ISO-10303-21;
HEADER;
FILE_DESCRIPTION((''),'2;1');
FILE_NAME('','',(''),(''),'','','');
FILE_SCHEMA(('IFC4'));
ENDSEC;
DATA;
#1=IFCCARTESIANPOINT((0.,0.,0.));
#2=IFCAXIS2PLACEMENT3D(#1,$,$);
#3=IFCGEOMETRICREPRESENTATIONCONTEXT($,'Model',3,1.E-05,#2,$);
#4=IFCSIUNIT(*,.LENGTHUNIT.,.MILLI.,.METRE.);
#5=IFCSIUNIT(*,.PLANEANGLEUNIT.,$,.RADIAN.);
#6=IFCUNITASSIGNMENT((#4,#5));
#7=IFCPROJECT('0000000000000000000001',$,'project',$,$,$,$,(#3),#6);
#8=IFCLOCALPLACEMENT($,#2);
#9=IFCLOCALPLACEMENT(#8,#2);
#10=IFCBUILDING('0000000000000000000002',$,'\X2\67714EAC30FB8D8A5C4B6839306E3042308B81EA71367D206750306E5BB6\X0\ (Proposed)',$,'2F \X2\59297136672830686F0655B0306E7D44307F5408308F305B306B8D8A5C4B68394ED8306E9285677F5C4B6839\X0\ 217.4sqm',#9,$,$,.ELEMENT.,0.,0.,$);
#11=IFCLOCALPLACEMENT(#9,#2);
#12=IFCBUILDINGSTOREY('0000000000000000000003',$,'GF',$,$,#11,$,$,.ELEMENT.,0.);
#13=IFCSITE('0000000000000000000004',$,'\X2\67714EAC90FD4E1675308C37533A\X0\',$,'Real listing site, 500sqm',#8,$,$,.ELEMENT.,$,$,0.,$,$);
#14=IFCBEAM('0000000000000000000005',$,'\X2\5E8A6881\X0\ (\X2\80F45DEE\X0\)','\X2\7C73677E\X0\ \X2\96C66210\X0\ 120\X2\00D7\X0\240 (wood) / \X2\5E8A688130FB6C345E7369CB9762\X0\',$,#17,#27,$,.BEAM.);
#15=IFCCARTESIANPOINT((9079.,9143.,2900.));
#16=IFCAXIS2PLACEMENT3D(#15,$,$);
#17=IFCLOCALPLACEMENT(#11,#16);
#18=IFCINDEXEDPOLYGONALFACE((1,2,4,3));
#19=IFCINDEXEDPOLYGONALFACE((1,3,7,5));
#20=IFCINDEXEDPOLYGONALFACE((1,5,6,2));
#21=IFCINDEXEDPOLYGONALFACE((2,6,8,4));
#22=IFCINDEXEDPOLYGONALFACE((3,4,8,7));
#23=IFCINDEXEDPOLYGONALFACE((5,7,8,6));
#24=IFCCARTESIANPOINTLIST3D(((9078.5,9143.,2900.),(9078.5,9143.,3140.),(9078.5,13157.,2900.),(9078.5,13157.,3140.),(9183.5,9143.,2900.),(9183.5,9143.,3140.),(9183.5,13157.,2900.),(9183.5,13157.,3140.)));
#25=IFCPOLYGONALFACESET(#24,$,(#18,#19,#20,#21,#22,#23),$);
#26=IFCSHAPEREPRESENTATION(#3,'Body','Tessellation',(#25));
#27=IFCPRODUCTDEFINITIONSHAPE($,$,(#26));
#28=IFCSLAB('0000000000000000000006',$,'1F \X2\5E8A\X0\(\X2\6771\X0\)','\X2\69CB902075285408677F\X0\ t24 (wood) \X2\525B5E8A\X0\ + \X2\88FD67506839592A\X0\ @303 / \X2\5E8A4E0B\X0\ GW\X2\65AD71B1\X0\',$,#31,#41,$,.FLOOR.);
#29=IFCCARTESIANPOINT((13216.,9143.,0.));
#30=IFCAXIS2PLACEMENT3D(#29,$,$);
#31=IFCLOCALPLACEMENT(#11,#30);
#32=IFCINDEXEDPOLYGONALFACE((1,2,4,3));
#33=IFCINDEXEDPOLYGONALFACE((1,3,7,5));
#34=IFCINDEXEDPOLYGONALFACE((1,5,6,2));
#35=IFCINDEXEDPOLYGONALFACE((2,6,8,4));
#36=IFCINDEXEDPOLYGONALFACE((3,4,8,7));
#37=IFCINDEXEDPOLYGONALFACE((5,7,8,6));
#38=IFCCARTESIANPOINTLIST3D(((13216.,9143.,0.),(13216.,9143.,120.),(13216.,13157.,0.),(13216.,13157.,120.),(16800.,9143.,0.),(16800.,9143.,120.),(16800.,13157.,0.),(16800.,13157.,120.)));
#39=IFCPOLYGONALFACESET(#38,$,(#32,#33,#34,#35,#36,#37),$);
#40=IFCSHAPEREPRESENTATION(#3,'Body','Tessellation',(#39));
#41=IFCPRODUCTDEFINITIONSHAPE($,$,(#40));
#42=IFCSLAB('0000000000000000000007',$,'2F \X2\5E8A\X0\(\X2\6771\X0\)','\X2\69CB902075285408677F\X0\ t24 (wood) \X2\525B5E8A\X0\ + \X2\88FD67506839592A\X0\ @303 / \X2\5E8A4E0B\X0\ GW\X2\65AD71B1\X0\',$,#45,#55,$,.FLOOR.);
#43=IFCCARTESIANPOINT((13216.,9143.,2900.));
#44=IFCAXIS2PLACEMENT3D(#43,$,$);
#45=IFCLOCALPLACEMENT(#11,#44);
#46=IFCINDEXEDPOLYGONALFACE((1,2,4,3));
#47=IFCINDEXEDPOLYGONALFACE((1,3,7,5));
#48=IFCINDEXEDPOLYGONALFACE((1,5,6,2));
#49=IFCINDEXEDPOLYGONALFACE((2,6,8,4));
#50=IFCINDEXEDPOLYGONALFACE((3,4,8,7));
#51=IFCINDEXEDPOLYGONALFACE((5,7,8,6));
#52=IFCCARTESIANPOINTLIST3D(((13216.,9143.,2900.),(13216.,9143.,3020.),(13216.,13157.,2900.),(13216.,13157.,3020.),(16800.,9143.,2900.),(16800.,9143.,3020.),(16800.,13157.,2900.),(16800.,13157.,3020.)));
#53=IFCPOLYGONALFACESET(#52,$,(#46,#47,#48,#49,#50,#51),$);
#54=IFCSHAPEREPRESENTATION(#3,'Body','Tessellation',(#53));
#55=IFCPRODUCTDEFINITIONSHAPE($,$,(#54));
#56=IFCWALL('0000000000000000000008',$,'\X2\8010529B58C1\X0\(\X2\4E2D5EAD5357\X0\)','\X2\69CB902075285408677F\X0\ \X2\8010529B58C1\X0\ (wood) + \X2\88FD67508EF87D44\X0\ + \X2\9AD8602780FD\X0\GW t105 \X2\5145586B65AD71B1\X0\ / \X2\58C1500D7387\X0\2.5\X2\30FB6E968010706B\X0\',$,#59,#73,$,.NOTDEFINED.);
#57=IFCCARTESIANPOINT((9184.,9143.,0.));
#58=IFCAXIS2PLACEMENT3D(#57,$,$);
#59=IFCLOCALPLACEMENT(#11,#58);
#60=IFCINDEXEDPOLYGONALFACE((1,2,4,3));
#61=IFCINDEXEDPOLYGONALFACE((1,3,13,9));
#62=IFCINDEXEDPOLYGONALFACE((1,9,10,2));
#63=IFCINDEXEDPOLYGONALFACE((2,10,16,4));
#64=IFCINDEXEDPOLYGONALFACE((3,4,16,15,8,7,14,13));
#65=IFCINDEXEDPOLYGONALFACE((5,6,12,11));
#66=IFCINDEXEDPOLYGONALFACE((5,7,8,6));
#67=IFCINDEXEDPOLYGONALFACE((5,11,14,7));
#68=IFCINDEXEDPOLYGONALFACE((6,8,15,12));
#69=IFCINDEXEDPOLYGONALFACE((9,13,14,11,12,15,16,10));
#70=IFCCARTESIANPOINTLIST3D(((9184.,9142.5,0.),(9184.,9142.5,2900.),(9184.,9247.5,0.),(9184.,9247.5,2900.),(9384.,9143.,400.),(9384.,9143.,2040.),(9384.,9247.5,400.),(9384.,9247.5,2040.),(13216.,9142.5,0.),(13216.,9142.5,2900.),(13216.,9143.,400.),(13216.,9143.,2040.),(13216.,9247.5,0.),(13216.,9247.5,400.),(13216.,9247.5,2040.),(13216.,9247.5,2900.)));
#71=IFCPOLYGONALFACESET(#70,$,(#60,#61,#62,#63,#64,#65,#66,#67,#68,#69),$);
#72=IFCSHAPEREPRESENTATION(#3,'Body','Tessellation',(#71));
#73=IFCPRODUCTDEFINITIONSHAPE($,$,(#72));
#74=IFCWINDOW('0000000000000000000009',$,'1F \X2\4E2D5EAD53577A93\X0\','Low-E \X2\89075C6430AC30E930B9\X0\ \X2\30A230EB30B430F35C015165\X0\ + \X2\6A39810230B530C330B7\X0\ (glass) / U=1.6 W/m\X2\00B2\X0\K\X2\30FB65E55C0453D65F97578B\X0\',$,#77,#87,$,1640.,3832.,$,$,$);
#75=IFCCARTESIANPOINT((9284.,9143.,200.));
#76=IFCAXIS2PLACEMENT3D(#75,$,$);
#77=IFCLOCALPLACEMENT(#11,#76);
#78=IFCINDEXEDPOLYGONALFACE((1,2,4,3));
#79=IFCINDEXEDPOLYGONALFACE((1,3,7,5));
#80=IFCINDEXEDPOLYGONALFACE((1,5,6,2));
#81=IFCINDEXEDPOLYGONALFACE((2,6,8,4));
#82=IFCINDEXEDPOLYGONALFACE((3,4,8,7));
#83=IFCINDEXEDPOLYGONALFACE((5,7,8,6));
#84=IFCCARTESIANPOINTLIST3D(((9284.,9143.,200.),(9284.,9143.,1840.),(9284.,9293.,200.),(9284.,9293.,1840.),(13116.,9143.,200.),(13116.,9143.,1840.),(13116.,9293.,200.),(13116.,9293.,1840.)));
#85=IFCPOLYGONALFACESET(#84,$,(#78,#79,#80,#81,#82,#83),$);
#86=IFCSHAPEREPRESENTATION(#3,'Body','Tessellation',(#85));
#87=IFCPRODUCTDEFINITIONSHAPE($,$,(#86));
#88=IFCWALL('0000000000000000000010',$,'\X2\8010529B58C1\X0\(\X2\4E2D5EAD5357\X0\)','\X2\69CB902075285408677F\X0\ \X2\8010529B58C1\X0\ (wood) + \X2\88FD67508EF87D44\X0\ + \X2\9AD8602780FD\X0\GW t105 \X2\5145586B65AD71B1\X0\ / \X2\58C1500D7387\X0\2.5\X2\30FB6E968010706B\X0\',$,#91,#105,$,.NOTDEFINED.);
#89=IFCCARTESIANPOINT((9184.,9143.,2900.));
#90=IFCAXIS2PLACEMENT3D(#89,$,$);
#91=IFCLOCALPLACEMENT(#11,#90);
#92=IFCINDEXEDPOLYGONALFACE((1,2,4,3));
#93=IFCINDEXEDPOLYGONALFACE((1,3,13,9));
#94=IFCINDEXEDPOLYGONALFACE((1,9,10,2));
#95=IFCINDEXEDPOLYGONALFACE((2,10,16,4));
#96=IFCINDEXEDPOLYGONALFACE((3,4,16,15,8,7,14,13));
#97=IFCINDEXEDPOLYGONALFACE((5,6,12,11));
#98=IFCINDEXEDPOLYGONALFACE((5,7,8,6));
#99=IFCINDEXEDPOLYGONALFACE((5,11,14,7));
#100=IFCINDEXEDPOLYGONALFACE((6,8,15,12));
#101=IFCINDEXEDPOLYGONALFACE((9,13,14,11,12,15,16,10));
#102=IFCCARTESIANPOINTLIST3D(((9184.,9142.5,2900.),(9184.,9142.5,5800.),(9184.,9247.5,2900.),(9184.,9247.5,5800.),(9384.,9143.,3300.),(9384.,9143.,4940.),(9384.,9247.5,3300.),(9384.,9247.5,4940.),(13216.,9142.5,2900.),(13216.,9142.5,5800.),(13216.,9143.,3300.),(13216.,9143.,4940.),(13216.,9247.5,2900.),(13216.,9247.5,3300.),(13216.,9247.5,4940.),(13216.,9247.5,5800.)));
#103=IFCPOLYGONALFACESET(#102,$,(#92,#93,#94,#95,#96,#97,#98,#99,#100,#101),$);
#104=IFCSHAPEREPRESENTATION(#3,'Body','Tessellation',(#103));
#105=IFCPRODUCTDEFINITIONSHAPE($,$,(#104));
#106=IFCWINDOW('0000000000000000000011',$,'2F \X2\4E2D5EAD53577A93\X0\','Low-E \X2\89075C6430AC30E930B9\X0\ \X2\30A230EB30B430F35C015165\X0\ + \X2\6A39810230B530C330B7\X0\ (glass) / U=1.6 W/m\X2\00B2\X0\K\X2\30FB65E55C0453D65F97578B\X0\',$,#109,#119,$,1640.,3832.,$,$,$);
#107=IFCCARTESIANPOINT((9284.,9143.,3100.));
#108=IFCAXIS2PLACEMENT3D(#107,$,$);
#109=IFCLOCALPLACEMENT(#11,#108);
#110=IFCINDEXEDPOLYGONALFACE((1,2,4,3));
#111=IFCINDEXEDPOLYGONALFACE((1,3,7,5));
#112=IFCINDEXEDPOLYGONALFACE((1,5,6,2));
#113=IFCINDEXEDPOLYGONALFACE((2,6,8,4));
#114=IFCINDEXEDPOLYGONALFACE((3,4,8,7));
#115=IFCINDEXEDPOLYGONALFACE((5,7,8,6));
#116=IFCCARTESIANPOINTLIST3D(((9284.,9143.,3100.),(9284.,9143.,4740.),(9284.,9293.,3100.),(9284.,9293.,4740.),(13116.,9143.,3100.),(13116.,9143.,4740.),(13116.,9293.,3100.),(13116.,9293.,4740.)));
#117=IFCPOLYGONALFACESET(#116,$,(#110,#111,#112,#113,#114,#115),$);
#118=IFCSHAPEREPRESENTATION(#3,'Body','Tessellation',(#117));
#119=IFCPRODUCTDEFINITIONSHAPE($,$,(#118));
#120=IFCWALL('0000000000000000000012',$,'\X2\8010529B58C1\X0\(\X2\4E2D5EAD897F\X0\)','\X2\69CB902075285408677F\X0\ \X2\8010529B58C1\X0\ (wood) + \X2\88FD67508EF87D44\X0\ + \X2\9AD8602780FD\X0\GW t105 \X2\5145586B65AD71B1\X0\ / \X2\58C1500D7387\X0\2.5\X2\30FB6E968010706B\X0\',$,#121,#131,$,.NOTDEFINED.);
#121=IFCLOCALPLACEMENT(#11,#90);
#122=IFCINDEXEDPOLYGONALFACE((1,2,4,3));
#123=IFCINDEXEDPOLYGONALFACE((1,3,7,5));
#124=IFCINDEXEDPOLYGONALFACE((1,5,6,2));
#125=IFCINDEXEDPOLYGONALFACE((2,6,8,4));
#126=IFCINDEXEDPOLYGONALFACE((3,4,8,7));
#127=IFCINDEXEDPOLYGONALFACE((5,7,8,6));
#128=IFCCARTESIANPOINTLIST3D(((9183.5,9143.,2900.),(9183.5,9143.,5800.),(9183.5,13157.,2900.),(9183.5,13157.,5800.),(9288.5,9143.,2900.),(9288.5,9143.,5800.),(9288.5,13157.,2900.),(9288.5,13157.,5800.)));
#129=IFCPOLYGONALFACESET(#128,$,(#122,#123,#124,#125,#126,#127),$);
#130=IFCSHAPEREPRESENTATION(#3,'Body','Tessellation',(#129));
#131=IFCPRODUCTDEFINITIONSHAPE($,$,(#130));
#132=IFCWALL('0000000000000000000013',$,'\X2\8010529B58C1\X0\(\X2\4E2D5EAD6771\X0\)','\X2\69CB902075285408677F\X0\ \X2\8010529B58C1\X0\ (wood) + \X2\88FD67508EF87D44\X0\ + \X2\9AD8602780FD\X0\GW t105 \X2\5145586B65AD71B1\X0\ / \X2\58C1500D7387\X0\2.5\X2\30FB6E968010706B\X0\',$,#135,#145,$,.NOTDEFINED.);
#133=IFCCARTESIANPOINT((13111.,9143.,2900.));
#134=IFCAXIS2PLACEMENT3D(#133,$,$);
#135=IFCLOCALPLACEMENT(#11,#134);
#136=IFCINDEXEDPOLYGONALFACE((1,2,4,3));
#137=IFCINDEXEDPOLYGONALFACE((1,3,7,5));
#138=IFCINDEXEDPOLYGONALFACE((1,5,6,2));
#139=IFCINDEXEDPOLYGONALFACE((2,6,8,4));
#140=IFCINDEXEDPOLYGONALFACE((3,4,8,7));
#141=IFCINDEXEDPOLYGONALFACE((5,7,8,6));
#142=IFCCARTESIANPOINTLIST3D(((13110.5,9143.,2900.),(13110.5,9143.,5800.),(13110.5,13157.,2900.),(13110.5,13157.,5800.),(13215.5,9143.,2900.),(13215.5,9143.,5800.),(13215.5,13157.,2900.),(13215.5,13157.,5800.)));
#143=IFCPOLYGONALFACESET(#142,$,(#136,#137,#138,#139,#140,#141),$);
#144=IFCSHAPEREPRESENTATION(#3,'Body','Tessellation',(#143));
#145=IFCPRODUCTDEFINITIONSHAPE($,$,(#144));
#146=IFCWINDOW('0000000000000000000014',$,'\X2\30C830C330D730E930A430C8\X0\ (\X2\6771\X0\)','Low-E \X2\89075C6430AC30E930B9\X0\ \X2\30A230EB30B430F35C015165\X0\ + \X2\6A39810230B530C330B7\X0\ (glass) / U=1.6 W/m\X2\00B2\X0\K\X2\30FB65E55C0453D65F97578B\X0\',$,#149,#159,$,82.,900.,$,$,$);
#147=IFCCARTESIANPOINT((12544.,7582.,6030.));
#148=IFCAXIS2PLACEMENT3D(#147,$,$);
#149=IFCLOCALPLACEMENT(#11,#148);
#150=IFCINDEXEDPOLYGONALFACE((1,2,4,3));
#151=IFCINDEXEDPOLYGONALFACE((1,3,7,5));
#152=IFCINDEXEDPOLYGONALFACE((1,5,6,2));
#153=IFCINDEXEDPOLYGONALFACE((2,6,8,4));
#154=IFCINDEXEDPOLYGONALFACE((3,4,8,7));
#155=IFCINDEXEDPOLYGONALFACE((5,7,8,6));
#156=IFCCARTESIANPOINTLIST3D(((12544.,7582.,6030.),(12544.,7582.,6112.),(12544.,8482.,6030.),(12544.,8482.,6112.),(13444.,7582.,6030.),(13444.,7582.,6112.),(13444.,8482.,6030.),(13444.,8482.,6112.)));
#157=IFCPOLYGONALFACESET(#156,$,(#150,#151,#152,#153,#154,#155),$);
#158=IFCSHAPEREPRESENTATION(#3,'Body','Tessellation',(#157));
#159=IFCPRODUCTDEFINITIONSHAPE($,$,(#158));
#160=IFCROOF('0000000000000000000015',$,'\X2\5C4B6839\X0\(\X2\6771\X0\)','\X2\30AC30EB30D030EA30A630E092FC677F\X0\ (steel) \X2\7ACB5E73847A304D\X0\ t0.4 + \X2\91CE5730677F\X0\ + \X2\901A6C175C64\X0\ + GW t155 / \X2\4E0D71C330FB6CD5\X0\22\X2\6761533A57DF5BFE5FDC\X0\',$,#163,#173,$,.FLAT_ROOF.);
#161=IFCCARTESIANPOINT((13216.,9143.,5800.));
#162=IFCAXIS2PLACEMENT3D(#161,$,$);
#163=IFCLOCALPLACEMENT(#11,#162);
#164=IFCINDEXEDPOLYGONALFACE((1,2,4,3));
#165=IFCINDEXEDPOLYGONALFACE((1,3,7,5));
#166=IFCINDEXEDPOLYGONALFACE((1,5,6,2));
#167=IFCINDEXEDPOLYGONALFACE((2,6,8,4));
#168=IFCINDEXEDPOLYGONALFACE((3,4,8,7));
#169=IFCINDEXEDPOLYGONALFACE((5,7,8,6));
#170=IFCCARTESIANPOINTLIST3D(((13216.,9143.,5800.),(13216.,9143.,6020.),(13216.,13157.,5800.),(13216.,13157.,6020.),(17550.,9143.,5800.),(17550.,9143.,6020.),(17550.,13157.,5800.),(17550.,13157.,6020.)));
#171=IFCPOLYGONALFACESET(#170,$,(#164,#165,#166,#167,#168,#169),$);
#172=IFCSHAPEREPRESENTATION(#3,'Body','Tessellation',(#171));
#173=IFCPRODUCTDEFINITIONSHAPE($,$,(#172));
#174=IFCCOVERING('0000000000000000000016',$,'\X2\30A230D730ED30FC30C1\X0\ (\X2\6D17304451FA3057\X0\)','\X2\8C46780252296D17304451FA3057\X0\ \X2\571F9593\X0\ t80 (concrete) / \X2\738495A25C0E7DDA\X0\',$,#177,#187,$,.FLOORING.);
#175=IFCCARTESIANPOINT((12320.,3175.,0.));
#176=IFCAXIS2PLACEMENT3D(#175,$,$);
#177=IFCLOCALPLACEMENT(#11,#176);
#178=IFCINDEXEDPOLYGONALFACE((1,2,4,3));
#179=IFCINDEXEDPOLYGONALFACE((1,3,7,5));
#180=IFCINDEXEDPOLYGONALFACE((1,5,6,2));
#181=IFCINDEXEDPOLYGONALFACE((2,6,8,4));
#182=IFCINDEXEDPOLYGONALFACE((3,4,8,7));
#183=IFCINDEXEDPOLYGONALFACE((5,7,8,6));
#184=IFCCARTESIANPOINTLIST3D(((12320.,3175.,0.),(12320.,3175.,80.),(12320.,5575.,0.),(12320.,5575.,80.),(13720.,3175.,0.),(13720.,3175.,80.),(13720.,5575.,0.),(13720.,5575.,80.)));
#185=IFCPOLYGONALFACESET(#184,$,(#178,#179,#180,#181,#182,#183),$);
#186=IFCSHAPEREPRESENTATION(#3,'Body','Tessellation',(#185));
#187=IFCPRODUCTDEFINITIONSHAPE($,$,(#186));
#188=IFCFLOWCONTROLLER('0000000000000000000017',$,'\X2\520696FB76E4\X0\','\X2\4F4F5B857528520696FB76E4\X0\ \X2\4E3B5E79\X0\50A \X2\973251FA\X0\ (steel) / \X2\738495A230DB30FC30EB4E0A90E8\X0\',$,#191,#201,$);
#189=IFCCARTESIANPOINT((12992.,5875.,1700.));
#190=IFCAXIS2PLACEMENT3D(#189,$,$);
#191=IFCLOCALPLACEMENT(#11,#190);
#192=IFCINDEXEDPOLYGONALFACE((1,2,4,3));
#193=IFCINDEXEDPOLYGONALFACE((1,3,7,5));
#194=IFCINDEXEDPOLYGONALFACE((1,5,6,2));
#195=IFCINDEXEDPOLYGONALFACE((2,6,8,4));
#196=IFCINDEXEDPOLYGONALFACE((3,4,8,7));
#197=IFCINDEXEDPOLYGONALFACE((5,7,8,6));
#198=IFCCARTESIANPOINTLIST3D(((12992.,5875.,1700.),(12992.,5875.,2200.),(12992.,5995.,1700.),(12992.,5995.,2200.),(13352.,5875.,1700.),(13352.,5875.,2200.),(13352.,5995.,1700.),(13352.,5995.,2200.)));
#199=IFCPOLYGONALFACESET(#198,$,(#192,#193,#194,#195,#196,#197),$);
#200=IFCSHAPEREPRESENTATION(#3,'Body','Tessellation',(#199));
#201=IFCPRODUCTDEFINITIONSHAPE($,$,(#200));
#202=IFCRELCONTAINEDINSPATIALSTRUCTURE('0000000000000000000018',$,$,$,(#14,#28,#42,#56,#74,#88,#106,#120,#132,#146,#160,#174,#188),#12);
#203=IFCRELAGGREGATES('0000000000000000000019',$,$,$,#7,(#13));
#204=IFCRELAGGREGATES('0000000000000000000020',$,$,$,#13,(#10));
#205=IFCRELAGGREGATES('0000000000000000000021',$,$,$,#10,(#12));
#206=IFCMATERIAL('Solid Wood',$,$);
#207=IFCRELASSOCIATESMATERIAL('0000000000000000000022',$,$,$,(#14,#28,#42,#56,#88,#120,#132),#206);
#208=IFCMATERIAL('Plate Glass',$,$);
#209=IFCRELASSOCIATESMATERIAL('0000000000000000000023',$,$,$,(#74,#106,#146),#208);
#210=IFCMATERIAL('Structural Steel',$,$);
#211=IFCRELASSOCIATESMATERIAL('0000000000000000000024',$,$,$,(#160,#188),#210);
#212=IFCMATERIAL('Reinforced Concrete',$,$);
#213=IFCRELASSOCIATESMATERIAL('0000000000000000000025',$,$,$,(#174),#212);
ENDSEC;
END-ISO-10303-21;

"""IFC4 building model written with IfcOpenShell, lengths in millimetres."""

from ifc_helpers import new_model, si_unit, frame, frame_2d, origin, place, context, project, spatial, rectangle, extrude, material, element, fill, save


model = new_model("IFC4")

# Units and contexts
model_context = context("Model", 3, precision=1e-05, world=origin())
ifc_project = project(units=[si_unit("LENGTHUNIT", "METRE", prefix="MILLI"), si_unit("PLANEANGLEUNIT", "RADIAN")], contexts=[model_context])

# Site, building, storey
site_placement = place(None, origin())
site = spatial("IfcSite", under=ifc_project, at=site_placement, Name="東京都世田谷区", ObjectType="Real listing site, 500sqm", CompositionType="ELEMENT", RefElevation=0.0)
building_placement = place(site_placement, origin())
building = spatial("IfcBuilding", under=site, at=building_placement, Name="東京・越屋根のある自然素材の家 (Proposed)", ObjectType="2F 天然木と漆喰の組み合わせに越屋根付の銅板屋根 217.4sqm", CompositionType="ELEMENT", ElevationOfRefHeight=0.0, ElevationOfTerrain=0.0)
storey_placement = place(building_placement, origin())
storey = spatial("IfcBuildingStorey", under=building, at=storey_placement, Name="GF", CompositionType="ELEMENT", Elevation=0.0)

# Shared definitions
ifc_material_1 = material(Name="Solid Wood")

# Beam
beam_placement = place(storey_placement, frame((9079.0, 9143.0, 2900.0)))
element("IfcBeam", 1, at=beam_placement, inside=storey, material=ifc_material_1, Name="床梁 (胴差)", Description="米松 集成 120×240 (wood) / 床梁・水平構面", PredefinedType="BEAM", context=model_context, shape_type="SweptSolid", body=[
    extrude(rectangle(XDim=105.0, YDim=4014.0, at=frame_2d((52.0, 2007.0))), frame((9079.0, 9143.0, 2900.0)), (0.0, 0.0, 1.0), 240.0),
])

# Slabs
slab_1_placement = place(storey_placement, frame((13216.0, 9143.0, 0.0)))
element("IfcSlab", 2, at=slab_1_placement, inside=storey, material=ifc_material_1, Name="1F 床(東)", Description="構造用合板 t24 (wood) 剛床 + 製材根太 @303 / 床下 GW断熱", PredefinedType="FLOOR", context=model_context, shape_type="SweptSolid", body=[
    extrude(rectangle(XDim=3584.0, YDim=4014.0, at=frame_2d((1792.0, 2007.0))), frame((13216.0, 9143.0, 0.0)), (0.0, 0.0, 1.0), 120.0),
])
slab_2_placement = place(storey_placement, frame((13216.0, 9143.0, 2900.0)))
element("IfcSlab", 3, at=slab_2_placement, inside=storey, material=ifc_material_1, Name="2F 床(東)", Description="構造用合板 t24 (wood) 剛床 + 製材根太 @303 / 床下 GW断熱", PredefinedType="FLOOR", context=model_context, shape_type="SweptSolid", body=[
    extrude(rectangle(XDim=3584.0, YDim=4014.0, at=frame_2d((1792.0, 2007.0))), frame((13216.0, 9143.0, 2900.0)), (0.0, 0.0, 1.0), 120.0),
])

# Wall, opening, window
wall_1_placement = place(storey_placement, frame((9184.0, 9143.0, 0.0)))
wall_1 = element("IfcWall", 4, at=wall_1_placement, inside=storey, material=ifc_material_1, Name="耐力壁(中庭南)", Description="構造用合板 耐力壁 (wood) + 製材軸組 + 高性能GW t105 充填断熱 / 壁倍率2.5・準耐火", PredefinedType="NOTDEFINED", context=model_context, shape_type="SweptSolid", body=[
    extrude(rectangle(XDim=4032.0, YDim=105.0, at=frame_2d((2016.0, 52.0))), frame((9184.0, 9143.0, 0.0)), (0.0, 0.0, 1.0), 2900.0),
])
opening_1_placement = place(storey_placement, frame((9284.0, 9143.0, 200.0)))
opening_1 = element("IfcOpeningElement", 5, at=opening_1_placement, cuts=wall_1, PredefinedType="NOTDEFINED", context=model_context, shape_type="SweptSolid", body=[
    extrude(rectangle(XDim=3832.0, YDim=150.0, at=frame_2d((1916.0, 75.0))), frame((9284.0, 9143.0, 200.0)), (0.0, 0.0, 1.0), 1640.0),
])
ifc_material_2 = material(Name="Plate Glass")
window_1_placement = place(storey_placement, frame((9284.0, 9143.0, 200.0)))
window_1 = element("IfcWindow", 6, at=window_1_placement, inside=storey, material=ifc_material_2, Name="1F 中庭南窓", Description="Low-E 複層ガラス アルゴン封入 + 樹脂サッシ (glass) / U=1.6 W/m²K・日射取得型", OverallHeight=1640.0, OverallWidth=3832.0, context=model_context, shape_type="SweptSolid", body=[
    extrude(rectangle(XDim=3832.0, YDim=150.0, at=frame_2d((1916.0, 75.0))), frame((9284.0, 9143.0, 200.0)), (0.0, 0.0, 1.0), 1640.0),
])
fill(opening_1, window_1)

# Wall, opening, window
wall_2_placement = place(storey_placement, frame((9184.0, 9143.0, 2900.0)))
wall_2 = element("IfcWall", 7, at=wall_2_placement, inside=storey, material=ifc_material_1, Name="耐力壁(中庭南)", Description="構造用合板 耐力壁 (wood) + 製材軸組 + 高性能GW t105 充填断熱 / 壁倍率2.5・準耐火", PredefinedType="NOTDEFINED", context=model_context, shape_type="SweptSolid", body=[
    extrude(rectangle(XDim=4032.0, YDim=105.0, at=frame_2d((2016.0, 52.0))), frame((9184.0, 9143.0, 2900.0)), (0.0, 0.0, 1.0), 2900.0),
])
opening_2_placement = place(storey_placement, frame((9284.0, 9143.0, 3100.0)))
opening_2 = element("IfcOpeningElement", 8, at=opening_2_placement, cuts=wall_2, PredefinedType="NOTDEFINED", context=model_context, shape_type="SweptSolid", body=[
    extrude(rectangle(XDim=3832.0, YDim=150.0, at=frame_2d((1916.0, 75.0))), frame((9284.0, 9143.0, 3100.0)), (0.0, 0.0, 1.0), 1640.0),
])
window_2_placement = place(storey_placement, frame((9284.0, 9143.0, 3100.0)))
window_2 = element("IfcWindow", 9, at=window_2_placement, inside=storey, material=ifc_material_2, Name="2F 中庭南窓", Description="Low-E 複層ガラス アルゴン封入 + 樹脂サッシ (glass) / U=1.6 W/m²K・日射取得型", OverallHeight=1640.0, OverallWidth=3832.0, context=model_context, shape_type="SweptSolid", body=[
    extrude(rectangle(XDim=3832.0, YDim=150.0, at=frame_2d((1916.0, 75.0))), frame((9284.0, 9143.0, 3100.0)), (0.0, 0.0, 1.0), 1640.0),
])
fill(opening_2, window_2)

# Walls
wall_3_placement = place(storey_placement, frame((9184.0, 9143.0, 2900.0)))
element("IfcWall", 10, at=wall_3_placement, inside=storey, material=ifc_material_1, Name="耐力壁(中庭西)", Description="構造用合板 耐力壁 (wood) + 製材軸組 + 高性能GW t105 充填断熱 / 壁倍率2.5・準耐火", PredefinedType="NOTDEFINED", context=model_context, shape_type="SweptSolid", body=[
    extrude(rectangle(XDim=105.0, YDim=4014.0, at=frame_2d((52.0, 2007.0))), frame((9184.0, 9143.0, 2900.0)), (0.0, 0.0, 1.0), 2900.0),
])
wall_4_placement = place(storey_placement, frame((13111.0, 9143.0, 2900.0)))
element("IfcWall", 11, at=wall_4_placement, inside=storey, material=ifc_material_1, Name="耐力壁(中庭東)", Description="構造用合板 耐力壁 (wood) + 製材軸組 + 高性能GW t105 充填断熱 / 壁倍率2.5・準耐火", PredefinedType="NOTDEFINED", context=model_context, shape_type="SweptSolid", body=[
    extrude(rectangle(XDim=105.0, YDim=4014.0, at=frame_2d((52.0, 2007.0))), frame((13111.0, 9143.0, 2900.0)), (0.0, 0.0, 1.0), 2900.0),
])

# Window
window_3_placement = place(storey_placement, frame((12544.0, 7582.0, 6030.0)))
element("IfcWindow", 12, at=window_3_placement, inside=storey, material=ifc_material_2, Name="トップライト (東)", Description="Low-E 複層ガラス アルゴン封入 + 樹脂サッシ (glass) / U=1.6 W/m²K・日射取得型", OverallHeight=82.0, OverallWidth=900.0, context=model_context, shape_type="SweptSolid", body=[
    extrude(rectangle(XDim=900.0, YDim=900.0, at=frame_2d((450.0, 450.0))), frame((12544.0, 7582.0, 6030.0)), (0.0, 0.0, 1.0), 82.0),
])

# Roof
ifc_material_3 = material(Name="Structural Steel")
for number, where, name in (
    (13, (13216.0, 9143.0, 5800.0), "屋根(東)"),
):
    element("IfcRoof", number, at=place(storey_placement, frame(where)), inside=storey, material=ifc_material_3, Name=name, Description="ガルバリウム鋼板 (steel) 立平葺き t0.4 + 野地板 + 通気層 + GW t155 / 不燃・法22条区域対応", PredefinedType="FLAT_ROOF", context=model_context, shape_type="SweptSolid", body=[
        extrude(rectangle(XDim=4334.0, YDim=4014.0, at=frame_2d((2167.0, 2007.0))), frame((13216.0, 9143.0, 5800.0)), (0.0, 0.0, 1.0), 220.0),
    ])

# Covering
ifc_material_4 = material(Name="Reinforced Concrete")
covering_placement = place(storey_placement, frame((12320.0, 3175.0, 0.0)))
element("IfcCovering", 14, at=covering_placement, inside=storey, material=ifc_material_4, Name="アプローチ (洗い出し)", Description="豆砂利洗い出し 土間 t80 (concrete) / 玄関導線", PredefinedType="FLOORING", context=model_context, shape_type="SweptSolid", body=[
    extrude(rectangle(XDim=1400.0, YDim=2400.0, at=frame_2d((700.0, 1200.0))), frame((12320.0, 3175.0, 0.0)), (0.0, 0.0, 1.0), 80.0),
])

# Flow controller
flow_controller_placement = place(storey_placement, frame((12992.0, 5875.0, 1700.0)))
element("IfcFlowController", 15, at=flow_controller_placement, inside=storey, material=ifc_material_3, Name="分電盤", Description="住宅用分電盤 主幹50A 露出 (steel) / 玄関ホール上部", context=model_context, shape_type="SweptSolid", body=[
    extrude(rectangle(XDim=360.0, YDim=120.0, at=frame_2d((180.0, 60.0))), frame((12992.0, 5875.0, 1700.0)), (0.0, 0.0, 1.0), 500.0),
])

save(model, "model.ifc")
